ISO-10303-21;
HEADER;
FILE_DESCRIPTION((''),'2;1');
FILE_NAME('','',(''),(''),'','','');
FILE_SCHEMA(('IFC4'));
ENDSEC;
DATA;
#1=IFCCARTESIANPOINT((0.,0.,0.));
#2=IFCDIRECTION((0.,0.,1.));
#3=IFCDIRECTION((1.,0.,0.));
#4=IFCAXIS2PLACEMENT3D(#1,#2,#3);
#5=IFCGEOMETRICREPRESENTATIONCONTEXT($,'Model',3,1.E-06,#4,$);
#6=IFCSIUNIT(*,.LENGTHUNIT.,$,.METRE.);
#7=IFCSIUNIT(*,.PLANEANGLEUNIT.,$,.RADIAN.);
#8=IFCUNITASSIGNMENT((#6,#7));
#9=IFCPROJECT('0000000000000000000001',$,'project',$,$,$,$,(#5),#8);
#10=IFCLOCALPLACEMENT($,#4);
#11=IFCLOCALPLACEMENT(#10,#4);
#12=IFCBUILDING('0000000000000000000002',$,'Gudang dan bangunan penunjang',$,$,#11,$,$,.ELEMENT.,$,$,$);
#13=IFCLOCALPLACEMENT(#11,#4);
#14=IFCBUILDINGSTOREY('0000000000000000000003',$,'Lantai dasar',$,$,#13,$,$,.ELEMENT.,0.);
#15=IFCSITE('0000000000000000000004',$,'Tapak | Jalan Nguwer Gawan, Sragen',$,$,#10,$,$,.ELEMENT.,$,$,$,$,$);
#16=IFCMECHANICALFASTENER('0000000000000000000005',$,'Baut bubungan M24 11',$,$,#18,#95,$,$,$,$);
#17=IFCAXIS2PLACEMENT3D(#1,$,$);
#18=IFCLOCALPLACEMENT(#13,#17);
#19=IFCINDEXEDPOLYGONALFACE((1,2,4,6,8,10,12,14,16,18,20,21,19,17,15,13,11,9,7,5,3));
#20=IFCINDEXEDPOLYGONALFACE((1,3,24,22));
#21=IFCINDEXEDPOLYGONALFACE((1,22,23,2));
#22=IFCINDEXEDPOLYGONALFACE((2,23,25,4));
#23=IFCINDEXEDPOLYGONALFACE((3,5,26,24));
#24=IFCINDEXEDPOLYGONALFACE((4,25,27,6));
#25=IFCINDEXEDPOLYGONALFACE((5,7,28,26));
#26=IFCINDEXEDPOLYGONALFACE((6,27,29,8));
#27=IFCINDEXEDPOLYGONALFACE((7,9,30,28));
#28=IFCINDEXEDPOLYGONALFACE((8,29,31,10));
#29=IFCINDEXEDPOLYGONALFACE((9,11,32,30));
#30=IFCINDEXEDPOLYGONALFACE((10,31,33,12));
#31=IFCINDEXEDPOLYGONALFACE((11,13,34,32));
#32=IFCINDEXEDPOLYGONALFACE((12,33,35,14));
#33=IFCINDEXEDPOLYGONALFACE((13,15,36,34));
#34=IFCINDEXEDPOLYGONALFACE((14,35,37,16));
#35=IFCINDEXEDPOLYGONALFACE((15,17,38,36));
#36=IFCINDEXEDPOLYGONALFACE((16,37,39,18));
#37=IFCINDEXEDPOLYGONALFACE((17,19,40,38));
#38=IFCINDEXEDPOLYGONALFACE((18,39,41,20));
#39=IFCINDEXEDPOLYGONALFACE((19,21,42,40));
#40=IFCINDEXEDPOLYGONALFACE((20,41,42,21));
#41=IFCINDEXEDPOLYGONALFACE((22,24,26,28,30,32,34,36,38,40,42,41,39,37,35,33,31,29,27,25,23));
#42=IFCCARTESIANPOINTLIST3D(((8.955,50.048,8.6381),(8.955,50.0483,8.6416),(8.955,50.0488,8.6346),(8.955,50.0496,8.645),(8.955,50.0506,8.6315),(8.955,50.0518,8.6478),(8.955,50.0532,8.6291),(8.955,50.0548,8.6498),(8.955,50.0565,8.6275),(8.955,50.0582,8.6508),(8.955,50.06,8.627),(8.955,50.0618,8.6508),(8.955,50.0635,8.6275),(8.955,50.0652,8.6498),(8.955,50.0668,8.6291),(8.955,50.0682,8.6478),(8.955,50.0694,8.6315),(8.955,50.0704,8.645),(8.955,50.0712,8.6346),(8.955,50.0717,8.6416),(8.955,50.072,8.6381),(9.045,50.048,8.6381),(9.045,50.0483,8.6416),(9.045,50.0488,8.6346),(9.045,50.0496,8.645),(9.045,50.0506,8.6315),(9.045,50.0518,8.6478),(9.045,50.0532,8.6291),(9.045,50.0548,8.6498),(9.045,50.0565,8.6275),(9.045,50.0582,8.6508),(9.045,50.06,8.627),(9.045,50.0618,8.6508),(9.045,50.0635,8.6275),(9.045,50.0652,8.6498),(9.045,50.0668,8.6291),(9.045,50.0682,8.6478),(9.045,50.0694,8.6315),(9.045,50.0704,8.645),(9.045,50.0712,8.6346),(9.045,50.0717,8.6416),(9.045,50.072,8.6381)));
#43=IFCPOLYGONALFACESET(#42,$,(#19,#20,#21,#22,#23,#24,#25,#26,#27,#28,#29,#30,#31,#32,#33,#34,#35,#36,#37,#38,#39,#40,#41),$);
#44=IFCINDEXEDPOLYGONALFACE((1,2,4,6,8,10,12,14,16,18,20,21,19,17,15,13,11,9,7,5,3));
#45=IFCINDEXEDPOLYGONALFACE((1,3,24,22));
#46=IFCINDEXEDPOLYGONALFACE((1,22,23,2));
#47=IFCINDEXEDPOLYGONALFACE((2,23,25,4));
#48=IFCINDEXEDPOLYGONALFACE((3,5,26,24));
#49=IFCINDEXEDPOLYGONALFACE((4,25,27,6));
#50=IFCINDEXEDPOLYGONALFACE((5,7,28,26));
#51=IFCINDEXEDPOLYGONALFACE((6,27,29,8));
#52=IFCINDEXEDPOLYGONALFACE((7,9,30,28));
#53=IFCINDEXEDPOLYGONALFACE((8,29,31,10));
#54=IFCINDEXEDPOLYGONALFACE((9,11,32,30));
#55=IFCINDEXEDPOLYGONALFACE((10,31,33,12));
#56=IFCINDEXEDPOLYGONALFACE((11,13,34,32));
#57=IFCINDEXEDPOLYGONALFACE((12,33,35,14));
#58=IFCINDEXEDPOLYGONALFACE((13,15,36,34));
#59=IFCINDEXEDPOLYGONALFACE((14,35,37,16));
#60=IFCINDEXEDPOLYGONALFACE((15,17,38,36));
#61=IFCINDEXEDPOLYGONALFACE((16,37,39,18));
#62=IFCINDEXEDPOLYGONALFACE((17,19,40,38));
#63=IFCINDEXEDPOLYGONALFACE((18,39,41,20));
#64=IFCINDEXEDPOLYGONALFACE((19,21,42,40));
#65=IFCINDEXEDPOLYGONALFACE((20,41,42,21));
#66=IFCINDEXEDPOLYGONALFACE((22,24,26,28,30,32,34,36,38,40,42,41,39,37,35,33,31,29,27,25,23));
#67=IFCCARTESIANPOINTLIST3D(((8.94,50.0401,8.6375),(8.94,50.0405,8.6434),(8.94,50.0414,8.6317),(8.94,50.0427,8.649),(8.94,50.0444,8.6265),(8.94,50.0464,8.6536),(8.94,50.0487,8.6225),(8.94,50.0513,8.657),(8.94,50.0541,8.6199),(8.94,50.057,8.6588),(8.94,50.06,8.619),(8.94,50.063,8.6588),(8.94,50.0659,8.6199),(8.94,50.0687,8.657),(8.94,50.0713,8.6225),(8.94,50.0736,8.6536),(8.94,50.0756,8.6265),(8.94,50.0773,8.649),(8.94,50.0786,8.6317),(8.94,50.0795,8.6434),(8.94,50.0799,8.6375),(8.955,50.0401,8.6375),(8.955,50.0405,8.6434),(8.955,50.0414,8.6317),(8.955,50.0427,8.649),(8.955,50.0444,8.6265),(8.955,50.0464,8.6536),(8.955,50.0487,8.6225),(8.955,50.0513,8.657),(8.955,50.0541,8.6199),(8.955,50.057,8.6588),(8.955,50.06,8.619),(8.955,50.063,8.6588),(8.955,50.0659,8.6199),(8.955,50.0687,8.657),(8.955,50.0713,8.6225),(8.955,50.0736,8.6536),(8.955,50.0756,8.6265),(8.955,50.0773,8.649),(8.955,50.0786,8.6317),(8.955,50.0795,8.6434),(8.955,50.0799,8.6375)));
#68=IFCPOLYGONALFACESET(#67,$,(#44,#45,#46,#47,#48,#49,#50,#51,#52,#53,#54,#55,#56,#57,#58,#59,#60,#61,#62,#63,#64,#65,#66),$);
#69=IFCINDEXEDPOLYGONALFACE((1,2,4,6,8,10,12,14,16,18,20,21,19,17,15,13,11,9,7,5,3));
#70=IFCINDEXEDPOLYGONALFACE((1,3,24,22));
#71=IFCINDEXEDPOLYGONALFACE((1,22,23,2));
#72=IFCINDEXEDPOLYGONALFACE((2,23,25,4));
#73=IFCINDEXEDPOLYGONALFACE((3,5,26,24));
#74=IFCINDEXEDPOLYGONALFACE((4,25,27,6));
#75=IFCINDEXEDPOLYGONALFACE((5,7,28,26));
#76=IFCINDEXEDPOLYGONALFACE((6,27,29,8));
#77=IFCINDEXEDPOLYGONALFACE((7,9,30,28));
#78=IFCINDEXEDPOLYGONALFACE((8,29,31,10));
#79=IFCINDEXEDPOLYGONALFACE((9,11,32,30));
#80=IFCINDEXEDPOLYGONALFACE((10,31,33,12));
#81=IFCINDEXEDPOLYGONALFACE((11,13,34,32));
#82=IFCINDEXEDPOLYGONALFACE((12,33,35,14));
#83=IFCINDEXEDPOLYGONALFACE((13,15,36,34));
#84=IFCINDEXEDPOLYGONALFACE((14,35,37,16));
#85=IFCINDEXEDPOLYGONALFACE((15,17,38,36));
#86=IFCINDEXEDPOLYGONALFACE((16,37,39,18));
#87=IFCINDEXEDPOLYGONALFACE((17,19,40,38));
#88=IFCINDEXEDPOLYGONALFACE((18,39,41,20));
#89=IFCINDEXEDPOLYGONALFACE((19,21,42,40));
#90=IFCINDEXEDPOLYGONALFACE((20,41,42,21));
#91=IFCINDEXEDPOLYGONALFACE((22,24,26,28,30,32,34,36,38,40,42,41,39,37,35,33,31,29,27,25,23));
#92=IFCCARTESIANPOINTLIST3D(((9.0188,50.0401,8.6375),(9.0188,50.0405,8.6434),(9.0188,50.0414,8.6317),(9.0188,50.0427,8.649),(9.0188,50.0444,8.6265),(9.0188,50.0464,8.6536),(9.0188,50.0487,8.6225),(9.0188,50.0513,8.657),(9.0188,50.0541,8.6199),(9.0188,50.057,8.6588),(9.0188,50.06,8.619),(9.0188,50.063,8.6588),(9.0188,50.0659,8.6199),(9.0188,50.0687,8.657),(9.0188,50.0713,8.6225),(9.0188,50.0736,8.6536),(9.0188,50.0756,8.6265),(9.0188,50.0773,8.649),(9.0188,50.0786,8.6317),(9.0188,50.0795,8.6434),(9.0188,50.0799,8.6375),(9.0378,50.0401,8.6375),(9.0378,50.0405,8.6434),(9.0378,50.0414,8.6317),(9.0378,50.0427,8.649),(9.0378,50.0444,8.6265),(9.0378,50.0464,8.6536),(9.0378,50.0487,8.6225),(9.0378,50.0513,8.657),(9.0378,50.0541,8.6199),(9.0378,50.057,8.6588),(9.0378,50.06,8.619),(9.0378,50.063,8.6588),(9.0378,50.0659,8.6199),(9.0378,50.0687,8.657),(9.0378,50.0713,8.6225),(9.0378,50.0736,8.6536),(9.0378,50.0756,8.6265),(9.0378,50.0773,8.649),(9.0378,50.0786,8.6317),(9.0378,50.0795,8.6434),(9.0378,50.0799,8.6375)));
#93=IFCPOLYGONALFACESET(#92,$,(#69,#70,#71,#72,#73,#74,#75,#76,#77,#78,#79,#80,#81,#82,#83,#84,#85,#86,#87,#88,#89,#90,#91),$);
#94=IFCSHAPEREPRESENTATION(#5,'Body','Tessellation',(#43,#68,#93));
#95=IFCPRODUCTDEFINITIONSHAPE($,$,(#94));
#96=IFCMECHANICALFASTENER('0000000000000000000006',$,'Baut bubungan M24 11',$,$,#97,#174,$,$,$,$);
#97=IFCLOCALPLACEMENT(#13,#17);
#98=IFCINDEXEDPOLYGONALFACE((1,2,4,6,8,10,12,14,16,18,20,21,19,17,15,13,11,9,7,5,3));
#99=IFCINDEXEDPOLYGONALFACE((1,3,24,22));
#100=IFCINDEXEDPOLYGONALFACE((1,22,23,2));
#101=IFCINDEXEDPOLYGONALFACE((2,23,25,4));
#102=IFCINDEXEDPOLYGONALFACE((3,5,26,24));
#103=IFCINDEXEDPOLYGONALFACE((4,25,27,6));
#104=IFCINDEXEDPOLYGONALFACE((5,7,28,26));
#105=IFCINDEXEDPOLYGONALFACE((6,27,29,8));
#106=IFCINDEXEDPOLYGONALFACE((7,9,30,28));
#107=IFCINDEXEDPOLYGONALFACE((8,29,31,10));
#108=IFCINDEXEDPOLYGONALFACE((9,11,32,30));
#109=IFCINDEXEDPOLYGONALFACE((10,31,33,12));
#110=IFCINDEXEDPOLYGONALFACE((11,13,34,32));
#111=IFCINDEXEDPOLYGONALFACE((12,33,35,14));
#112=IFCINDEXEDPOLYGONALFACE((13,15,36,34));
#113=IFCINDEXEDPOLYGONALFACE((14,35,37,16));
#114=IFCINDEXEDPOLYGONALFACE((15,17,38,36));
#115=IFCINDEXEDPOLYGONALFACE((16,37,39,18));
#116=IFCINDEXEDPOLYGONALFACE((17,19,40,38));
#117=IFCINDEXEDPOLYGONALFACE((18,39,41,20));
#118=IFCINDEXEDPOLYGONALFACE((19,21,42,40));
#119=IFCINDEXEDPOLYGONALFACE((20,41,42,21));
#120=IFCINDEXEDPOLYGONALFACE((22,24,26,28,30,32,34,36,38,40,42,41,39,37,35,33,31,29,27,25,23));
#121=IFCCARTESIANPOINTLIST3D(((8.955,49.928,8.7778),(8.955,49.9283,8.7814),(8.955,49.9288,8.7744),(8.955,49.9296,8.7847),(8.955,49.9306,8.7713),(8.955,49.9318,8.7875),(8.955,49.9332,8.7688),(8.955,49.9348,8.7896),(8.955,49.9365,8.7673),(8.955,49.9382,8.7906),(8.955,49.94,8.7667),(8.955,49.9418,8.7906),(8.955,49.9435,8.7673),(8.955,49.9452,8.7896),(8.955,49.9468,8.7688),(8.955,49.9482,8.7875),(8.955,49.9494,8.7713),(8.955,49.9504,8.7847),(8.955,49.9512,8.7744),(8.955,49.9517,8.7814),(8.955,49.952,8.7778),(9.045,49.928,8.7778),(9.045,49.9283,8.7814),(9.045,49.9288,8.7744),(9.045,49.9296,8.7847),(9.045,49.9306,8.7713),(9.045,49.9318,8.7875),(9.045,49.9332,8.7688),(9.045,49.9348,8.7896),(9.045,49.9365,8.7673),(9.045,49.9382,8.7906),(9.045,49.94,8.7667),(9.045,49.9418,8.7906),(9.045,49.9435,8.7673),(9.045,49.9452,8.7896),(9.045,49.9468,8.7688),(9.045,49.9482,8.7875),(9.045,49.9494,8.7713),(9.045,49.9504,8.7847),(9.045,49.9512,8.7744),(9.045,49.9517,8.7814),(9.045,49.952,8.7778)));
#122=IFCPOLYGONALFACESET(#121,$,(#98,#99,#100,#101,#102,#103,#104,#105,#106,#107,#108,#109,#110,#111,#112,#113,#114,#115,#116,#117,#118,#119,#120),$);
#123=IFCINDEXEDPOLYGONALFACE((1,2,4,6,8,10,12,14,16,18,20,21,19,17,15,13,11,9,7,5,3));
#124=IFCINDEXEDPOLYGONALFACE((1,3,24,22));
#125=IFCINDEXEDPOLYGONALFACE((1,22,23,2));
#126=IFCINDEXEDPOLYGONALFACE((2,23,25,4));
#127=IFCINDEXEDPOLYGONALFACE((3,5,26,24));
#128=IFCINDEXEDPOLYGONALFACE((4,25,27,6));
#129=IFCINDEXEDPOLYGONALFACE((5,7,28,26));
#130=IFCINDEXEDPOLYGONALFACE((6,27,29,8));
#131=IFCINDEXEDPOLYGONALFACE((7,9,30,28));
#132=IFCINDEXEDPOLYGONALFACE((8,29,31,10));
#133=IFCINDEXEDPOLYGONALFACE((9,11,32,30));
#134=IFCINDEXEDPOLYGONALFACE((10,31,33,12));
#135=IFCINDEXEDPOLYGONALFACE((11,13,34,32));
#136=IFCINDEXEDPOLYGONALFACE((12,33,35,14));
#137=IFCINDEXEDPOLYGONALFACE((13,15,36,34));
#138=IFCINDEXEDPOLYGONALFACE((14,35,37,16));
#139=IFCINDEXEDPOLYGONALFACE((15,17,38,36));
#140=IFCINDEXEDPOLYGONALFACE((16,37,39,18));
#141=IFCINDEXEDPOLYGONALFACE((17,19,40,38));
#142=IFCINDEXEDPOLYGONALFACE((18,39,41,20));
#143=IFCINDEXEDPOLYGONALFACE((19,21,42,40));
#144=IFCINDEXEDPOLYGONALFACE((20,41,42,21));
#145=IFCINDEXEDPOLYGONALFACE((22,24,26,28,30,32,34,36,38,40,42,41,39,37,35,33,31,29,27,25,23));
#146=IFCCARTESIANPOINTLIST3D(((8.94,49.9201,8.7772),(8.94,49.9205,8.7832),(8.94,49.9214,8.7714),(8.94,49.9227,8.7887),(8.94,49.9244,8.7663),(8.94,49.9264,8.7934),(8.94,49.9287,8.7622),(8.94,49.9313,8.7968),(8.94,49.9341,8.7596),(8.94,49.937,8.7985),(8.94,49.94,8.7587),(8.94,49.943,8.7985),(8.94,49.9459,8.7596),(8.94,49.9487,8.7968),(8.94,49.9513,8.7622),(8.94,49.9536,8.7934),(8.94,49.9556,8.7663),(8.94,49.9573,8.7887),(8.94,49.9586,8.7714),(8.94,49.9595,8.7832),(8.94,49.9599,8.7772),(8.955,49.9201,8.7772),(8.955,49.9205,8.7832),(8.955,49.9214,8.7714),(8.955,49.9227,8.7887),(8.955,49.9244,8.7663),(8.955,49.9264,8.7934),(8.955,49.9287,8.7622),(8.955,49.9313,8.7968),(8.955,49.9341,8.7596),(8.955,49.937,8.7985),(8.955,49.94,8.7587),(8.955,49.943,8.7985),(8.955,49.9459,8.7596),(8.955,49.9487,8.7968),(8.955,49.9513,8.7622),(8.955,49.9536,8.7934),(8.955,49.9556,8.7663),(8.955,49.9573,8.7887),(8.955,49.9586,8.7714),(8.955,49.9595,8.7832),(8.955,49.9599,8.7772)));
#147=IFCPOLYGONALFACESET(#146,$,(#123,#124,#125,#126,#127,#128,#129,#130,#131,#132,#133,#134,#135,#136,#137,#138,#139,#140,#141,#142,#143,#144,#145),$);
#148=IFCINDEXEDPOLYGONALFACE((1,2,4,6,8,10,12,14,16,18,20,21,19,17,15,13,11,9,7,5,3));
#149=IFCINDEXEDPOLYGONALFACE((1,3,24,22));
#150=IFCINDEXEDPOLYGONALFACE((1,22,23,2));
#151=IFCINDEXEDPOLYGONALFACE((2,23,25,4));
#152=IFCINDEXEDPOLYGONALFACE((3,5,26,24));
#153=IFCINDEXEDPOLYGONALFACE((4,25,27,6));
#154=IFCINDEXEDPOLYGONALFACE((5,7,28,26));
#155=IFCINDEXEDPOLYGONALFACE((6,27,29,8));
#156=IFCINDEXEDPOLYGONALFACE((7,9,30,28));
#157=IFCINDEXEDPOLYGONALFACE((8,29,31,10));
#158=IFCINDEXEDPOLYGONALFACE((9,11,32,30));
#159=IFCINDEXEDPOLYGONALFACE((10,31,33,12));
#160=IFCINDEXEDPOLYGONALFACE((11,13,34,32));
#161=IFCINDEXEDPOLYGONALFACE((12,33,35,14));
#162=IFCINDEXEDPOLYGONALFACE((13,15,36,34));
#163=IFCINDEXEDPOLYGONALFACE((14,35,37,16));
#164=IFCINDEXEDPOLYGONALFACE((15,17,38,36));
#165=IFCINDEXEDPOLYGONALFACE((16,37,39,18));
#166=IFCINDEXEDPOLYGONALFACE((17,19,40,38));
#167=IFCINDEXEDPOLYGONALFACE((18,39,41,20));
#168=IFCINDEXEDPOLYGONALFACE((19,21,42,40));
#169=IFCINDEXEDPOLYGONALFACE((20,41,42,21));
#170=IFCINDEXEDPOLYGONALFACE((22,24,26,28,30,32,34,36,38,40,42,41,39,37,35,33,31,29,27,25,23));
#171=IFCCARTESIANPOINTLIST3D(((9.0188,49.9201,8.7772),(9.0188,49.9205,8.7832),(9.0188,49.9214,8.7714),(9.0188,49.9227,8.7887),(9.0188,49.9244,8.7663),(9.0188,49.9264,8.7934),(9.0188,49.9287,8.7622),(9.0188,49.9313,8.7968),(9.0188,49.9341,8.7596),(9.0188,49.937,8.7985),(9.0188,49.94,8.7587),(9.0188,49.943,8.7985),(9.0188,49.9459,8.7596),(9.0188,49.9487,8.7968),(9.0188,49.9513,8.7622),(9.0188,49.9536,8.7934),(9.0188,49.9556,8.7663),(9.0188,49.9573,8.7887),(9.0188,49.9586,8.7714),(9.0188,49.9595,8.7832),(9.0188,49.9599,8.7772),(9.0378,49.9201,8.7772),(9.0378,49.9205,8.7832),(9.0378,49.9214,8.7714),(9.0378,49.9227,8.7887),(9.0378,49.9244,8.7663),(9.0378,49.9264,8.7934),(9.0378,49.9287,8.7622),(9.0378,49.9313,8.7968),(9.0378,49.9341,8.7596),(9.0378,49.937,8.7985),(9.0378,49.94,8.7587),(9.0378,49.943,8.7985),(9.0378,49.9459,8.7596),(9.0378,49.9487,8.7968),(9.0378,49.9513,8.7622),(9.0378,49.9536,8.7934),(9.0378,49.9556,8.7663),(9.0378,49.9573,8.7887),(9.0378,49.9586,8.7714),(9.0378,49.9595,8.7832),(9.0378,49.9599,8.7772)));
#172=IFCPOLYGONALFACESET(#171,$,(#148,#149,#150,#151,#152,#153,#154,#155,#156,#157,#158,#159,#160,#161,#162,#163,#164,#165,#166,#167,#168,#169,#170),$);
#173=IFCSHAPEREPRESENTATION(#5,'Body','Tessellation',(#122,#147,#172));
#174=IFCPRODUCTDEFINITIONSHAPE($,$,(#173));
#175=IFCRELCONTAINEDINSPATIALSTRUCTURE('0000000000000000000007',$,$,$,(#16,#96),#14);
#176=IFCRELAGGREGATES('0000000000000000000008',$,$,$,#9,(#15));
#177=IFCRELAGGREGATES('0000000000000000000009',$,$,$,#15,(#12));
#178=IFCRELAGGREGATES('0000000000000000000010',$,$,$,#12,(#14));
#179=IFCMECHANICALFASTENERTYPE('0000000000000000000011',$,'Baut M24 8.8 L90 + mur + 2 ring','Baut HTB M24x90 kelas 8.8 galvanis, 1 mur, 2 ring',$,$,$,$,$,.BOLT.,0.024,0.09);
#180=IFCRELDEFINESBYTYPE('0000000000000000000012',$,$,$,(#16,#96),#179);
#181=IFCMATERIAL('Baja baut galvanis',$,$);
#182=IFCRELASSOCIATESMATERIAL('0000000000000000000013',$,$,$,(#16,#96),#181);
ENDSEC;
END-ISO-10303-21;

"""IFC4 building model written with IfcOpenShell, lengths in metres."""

from ifc_helpers import new_model, si_unit, frame, origin_with_axes, place, context, project, spatial, circle, extrude, source, transform, mapped, material, type_object, type_shapes, element, save


model = new_model("IFC4")

# Units and contexts
model_context = context("Model", 3, precision=1e-06, world=origin_with_axes())
ifc_project = project(units=[si_unit("LENGTHUNIT", "METRE"), si_unit("PLANEANGLEUNIT", "RADIAN")], contexts=[model_context])

# Site, building, storey
site_placement = place(None, origin_with_axes())
site = spatial("IfcSite", under=ifc_project, at=site_placement, Name="Tapak | Jalan Nguwer Gawan, Sragen", CompositionType="ELEMENT")
building_placement = place(site_placement, origin_with_axes())
building = spatial("IfcBuilding", under=site, at=building_placement, Name="Gudang dan bangunan penunjang", CompositionType="ELEMENT")
storey_placement = place(building_placement, origin_with_axes())
storey = spatial("IfcBuildingStorey", under=building, at=storey_placement, Name="Lantai dasar", CompositionType="ELEMENT", Elevation=0.0)

# Shared definitions
placement = place(None, origin_with_axes())

# Mechanical fasteners
ifc_material_1 = material(Name="Baja baut galvanis")
mechanical_fastener_type_1 = type_object("IfcMechanicalFastenerType", Name="Baut M24 8.8 L90 + mur + 2 ring", Description="Baut HTB M24x90 kelas 8.8 galvanis, 1 mur, 2 ring", NominalDiameter=0.024, NominalLength=0.09, PredefinedType="BOLT")
shared_shape_1 = source(origin_with_axes(), model_context, "Body", "SweptSolid", [
    extrude(circle(Radius=0.012), origin_with_axes(), (0.0, 0.0, 1.0), 0.09),
    extrude(circle(Radius=0.02), frame((0.0, 0.0, -0.015), z_axis=(0.0, 0.0, 1.0), x_axis=(1.0, 0.0, 0.0)), (0.0, 0.0, 1.0), 0.015),
    extrude(circle(Radius=0.02), frame((0.0, 0.0, 0.0638), z_axis=(0.0, 0.0, 1.0), x_axis=(1.0, 0.0, 0.0)), (0.0, 0.0, 1.0), 0.019),
])
type_shapes(mechanical_fastener_type_1, [shared_shape_1])
element("IfcMechanicalFastener", 1, at=placement, inside=storey, type_object=mechanical_fastener_type_1, material=ifc_material_1, Name="Baut bubungan M24 11", context=model_context, shape_type="MappedRepresentation", body=[
    mapped(shared_shape_1, transform((8.955, 50.06, 8.639), x_axis=(0.0, 0.0, -1.0), y_axis=(0.0, 1.0, 0.0), z_axis=(1.0, 0.0, 0.0), scale=1.0)),
])
element("IfcMechanicalFastener", 2, at=placement, inside=storey, type_object=mechanical_fastener_type_1, material=ifc_material_1, Name="Baut bubungan M24 11", context=model_context, shape_type="MappedRepresentation", body=[
    mapped(shared_shape_1, transform((8.955, 49.94, 8.7787), x_axis=(0.0, 0.0, -1.0), y_axis=(0.0, 1.0, 0.0), z_axis=(1.0, 0.0, 0.0), scale=1.0)),
])

save(model, "model.ifc")
